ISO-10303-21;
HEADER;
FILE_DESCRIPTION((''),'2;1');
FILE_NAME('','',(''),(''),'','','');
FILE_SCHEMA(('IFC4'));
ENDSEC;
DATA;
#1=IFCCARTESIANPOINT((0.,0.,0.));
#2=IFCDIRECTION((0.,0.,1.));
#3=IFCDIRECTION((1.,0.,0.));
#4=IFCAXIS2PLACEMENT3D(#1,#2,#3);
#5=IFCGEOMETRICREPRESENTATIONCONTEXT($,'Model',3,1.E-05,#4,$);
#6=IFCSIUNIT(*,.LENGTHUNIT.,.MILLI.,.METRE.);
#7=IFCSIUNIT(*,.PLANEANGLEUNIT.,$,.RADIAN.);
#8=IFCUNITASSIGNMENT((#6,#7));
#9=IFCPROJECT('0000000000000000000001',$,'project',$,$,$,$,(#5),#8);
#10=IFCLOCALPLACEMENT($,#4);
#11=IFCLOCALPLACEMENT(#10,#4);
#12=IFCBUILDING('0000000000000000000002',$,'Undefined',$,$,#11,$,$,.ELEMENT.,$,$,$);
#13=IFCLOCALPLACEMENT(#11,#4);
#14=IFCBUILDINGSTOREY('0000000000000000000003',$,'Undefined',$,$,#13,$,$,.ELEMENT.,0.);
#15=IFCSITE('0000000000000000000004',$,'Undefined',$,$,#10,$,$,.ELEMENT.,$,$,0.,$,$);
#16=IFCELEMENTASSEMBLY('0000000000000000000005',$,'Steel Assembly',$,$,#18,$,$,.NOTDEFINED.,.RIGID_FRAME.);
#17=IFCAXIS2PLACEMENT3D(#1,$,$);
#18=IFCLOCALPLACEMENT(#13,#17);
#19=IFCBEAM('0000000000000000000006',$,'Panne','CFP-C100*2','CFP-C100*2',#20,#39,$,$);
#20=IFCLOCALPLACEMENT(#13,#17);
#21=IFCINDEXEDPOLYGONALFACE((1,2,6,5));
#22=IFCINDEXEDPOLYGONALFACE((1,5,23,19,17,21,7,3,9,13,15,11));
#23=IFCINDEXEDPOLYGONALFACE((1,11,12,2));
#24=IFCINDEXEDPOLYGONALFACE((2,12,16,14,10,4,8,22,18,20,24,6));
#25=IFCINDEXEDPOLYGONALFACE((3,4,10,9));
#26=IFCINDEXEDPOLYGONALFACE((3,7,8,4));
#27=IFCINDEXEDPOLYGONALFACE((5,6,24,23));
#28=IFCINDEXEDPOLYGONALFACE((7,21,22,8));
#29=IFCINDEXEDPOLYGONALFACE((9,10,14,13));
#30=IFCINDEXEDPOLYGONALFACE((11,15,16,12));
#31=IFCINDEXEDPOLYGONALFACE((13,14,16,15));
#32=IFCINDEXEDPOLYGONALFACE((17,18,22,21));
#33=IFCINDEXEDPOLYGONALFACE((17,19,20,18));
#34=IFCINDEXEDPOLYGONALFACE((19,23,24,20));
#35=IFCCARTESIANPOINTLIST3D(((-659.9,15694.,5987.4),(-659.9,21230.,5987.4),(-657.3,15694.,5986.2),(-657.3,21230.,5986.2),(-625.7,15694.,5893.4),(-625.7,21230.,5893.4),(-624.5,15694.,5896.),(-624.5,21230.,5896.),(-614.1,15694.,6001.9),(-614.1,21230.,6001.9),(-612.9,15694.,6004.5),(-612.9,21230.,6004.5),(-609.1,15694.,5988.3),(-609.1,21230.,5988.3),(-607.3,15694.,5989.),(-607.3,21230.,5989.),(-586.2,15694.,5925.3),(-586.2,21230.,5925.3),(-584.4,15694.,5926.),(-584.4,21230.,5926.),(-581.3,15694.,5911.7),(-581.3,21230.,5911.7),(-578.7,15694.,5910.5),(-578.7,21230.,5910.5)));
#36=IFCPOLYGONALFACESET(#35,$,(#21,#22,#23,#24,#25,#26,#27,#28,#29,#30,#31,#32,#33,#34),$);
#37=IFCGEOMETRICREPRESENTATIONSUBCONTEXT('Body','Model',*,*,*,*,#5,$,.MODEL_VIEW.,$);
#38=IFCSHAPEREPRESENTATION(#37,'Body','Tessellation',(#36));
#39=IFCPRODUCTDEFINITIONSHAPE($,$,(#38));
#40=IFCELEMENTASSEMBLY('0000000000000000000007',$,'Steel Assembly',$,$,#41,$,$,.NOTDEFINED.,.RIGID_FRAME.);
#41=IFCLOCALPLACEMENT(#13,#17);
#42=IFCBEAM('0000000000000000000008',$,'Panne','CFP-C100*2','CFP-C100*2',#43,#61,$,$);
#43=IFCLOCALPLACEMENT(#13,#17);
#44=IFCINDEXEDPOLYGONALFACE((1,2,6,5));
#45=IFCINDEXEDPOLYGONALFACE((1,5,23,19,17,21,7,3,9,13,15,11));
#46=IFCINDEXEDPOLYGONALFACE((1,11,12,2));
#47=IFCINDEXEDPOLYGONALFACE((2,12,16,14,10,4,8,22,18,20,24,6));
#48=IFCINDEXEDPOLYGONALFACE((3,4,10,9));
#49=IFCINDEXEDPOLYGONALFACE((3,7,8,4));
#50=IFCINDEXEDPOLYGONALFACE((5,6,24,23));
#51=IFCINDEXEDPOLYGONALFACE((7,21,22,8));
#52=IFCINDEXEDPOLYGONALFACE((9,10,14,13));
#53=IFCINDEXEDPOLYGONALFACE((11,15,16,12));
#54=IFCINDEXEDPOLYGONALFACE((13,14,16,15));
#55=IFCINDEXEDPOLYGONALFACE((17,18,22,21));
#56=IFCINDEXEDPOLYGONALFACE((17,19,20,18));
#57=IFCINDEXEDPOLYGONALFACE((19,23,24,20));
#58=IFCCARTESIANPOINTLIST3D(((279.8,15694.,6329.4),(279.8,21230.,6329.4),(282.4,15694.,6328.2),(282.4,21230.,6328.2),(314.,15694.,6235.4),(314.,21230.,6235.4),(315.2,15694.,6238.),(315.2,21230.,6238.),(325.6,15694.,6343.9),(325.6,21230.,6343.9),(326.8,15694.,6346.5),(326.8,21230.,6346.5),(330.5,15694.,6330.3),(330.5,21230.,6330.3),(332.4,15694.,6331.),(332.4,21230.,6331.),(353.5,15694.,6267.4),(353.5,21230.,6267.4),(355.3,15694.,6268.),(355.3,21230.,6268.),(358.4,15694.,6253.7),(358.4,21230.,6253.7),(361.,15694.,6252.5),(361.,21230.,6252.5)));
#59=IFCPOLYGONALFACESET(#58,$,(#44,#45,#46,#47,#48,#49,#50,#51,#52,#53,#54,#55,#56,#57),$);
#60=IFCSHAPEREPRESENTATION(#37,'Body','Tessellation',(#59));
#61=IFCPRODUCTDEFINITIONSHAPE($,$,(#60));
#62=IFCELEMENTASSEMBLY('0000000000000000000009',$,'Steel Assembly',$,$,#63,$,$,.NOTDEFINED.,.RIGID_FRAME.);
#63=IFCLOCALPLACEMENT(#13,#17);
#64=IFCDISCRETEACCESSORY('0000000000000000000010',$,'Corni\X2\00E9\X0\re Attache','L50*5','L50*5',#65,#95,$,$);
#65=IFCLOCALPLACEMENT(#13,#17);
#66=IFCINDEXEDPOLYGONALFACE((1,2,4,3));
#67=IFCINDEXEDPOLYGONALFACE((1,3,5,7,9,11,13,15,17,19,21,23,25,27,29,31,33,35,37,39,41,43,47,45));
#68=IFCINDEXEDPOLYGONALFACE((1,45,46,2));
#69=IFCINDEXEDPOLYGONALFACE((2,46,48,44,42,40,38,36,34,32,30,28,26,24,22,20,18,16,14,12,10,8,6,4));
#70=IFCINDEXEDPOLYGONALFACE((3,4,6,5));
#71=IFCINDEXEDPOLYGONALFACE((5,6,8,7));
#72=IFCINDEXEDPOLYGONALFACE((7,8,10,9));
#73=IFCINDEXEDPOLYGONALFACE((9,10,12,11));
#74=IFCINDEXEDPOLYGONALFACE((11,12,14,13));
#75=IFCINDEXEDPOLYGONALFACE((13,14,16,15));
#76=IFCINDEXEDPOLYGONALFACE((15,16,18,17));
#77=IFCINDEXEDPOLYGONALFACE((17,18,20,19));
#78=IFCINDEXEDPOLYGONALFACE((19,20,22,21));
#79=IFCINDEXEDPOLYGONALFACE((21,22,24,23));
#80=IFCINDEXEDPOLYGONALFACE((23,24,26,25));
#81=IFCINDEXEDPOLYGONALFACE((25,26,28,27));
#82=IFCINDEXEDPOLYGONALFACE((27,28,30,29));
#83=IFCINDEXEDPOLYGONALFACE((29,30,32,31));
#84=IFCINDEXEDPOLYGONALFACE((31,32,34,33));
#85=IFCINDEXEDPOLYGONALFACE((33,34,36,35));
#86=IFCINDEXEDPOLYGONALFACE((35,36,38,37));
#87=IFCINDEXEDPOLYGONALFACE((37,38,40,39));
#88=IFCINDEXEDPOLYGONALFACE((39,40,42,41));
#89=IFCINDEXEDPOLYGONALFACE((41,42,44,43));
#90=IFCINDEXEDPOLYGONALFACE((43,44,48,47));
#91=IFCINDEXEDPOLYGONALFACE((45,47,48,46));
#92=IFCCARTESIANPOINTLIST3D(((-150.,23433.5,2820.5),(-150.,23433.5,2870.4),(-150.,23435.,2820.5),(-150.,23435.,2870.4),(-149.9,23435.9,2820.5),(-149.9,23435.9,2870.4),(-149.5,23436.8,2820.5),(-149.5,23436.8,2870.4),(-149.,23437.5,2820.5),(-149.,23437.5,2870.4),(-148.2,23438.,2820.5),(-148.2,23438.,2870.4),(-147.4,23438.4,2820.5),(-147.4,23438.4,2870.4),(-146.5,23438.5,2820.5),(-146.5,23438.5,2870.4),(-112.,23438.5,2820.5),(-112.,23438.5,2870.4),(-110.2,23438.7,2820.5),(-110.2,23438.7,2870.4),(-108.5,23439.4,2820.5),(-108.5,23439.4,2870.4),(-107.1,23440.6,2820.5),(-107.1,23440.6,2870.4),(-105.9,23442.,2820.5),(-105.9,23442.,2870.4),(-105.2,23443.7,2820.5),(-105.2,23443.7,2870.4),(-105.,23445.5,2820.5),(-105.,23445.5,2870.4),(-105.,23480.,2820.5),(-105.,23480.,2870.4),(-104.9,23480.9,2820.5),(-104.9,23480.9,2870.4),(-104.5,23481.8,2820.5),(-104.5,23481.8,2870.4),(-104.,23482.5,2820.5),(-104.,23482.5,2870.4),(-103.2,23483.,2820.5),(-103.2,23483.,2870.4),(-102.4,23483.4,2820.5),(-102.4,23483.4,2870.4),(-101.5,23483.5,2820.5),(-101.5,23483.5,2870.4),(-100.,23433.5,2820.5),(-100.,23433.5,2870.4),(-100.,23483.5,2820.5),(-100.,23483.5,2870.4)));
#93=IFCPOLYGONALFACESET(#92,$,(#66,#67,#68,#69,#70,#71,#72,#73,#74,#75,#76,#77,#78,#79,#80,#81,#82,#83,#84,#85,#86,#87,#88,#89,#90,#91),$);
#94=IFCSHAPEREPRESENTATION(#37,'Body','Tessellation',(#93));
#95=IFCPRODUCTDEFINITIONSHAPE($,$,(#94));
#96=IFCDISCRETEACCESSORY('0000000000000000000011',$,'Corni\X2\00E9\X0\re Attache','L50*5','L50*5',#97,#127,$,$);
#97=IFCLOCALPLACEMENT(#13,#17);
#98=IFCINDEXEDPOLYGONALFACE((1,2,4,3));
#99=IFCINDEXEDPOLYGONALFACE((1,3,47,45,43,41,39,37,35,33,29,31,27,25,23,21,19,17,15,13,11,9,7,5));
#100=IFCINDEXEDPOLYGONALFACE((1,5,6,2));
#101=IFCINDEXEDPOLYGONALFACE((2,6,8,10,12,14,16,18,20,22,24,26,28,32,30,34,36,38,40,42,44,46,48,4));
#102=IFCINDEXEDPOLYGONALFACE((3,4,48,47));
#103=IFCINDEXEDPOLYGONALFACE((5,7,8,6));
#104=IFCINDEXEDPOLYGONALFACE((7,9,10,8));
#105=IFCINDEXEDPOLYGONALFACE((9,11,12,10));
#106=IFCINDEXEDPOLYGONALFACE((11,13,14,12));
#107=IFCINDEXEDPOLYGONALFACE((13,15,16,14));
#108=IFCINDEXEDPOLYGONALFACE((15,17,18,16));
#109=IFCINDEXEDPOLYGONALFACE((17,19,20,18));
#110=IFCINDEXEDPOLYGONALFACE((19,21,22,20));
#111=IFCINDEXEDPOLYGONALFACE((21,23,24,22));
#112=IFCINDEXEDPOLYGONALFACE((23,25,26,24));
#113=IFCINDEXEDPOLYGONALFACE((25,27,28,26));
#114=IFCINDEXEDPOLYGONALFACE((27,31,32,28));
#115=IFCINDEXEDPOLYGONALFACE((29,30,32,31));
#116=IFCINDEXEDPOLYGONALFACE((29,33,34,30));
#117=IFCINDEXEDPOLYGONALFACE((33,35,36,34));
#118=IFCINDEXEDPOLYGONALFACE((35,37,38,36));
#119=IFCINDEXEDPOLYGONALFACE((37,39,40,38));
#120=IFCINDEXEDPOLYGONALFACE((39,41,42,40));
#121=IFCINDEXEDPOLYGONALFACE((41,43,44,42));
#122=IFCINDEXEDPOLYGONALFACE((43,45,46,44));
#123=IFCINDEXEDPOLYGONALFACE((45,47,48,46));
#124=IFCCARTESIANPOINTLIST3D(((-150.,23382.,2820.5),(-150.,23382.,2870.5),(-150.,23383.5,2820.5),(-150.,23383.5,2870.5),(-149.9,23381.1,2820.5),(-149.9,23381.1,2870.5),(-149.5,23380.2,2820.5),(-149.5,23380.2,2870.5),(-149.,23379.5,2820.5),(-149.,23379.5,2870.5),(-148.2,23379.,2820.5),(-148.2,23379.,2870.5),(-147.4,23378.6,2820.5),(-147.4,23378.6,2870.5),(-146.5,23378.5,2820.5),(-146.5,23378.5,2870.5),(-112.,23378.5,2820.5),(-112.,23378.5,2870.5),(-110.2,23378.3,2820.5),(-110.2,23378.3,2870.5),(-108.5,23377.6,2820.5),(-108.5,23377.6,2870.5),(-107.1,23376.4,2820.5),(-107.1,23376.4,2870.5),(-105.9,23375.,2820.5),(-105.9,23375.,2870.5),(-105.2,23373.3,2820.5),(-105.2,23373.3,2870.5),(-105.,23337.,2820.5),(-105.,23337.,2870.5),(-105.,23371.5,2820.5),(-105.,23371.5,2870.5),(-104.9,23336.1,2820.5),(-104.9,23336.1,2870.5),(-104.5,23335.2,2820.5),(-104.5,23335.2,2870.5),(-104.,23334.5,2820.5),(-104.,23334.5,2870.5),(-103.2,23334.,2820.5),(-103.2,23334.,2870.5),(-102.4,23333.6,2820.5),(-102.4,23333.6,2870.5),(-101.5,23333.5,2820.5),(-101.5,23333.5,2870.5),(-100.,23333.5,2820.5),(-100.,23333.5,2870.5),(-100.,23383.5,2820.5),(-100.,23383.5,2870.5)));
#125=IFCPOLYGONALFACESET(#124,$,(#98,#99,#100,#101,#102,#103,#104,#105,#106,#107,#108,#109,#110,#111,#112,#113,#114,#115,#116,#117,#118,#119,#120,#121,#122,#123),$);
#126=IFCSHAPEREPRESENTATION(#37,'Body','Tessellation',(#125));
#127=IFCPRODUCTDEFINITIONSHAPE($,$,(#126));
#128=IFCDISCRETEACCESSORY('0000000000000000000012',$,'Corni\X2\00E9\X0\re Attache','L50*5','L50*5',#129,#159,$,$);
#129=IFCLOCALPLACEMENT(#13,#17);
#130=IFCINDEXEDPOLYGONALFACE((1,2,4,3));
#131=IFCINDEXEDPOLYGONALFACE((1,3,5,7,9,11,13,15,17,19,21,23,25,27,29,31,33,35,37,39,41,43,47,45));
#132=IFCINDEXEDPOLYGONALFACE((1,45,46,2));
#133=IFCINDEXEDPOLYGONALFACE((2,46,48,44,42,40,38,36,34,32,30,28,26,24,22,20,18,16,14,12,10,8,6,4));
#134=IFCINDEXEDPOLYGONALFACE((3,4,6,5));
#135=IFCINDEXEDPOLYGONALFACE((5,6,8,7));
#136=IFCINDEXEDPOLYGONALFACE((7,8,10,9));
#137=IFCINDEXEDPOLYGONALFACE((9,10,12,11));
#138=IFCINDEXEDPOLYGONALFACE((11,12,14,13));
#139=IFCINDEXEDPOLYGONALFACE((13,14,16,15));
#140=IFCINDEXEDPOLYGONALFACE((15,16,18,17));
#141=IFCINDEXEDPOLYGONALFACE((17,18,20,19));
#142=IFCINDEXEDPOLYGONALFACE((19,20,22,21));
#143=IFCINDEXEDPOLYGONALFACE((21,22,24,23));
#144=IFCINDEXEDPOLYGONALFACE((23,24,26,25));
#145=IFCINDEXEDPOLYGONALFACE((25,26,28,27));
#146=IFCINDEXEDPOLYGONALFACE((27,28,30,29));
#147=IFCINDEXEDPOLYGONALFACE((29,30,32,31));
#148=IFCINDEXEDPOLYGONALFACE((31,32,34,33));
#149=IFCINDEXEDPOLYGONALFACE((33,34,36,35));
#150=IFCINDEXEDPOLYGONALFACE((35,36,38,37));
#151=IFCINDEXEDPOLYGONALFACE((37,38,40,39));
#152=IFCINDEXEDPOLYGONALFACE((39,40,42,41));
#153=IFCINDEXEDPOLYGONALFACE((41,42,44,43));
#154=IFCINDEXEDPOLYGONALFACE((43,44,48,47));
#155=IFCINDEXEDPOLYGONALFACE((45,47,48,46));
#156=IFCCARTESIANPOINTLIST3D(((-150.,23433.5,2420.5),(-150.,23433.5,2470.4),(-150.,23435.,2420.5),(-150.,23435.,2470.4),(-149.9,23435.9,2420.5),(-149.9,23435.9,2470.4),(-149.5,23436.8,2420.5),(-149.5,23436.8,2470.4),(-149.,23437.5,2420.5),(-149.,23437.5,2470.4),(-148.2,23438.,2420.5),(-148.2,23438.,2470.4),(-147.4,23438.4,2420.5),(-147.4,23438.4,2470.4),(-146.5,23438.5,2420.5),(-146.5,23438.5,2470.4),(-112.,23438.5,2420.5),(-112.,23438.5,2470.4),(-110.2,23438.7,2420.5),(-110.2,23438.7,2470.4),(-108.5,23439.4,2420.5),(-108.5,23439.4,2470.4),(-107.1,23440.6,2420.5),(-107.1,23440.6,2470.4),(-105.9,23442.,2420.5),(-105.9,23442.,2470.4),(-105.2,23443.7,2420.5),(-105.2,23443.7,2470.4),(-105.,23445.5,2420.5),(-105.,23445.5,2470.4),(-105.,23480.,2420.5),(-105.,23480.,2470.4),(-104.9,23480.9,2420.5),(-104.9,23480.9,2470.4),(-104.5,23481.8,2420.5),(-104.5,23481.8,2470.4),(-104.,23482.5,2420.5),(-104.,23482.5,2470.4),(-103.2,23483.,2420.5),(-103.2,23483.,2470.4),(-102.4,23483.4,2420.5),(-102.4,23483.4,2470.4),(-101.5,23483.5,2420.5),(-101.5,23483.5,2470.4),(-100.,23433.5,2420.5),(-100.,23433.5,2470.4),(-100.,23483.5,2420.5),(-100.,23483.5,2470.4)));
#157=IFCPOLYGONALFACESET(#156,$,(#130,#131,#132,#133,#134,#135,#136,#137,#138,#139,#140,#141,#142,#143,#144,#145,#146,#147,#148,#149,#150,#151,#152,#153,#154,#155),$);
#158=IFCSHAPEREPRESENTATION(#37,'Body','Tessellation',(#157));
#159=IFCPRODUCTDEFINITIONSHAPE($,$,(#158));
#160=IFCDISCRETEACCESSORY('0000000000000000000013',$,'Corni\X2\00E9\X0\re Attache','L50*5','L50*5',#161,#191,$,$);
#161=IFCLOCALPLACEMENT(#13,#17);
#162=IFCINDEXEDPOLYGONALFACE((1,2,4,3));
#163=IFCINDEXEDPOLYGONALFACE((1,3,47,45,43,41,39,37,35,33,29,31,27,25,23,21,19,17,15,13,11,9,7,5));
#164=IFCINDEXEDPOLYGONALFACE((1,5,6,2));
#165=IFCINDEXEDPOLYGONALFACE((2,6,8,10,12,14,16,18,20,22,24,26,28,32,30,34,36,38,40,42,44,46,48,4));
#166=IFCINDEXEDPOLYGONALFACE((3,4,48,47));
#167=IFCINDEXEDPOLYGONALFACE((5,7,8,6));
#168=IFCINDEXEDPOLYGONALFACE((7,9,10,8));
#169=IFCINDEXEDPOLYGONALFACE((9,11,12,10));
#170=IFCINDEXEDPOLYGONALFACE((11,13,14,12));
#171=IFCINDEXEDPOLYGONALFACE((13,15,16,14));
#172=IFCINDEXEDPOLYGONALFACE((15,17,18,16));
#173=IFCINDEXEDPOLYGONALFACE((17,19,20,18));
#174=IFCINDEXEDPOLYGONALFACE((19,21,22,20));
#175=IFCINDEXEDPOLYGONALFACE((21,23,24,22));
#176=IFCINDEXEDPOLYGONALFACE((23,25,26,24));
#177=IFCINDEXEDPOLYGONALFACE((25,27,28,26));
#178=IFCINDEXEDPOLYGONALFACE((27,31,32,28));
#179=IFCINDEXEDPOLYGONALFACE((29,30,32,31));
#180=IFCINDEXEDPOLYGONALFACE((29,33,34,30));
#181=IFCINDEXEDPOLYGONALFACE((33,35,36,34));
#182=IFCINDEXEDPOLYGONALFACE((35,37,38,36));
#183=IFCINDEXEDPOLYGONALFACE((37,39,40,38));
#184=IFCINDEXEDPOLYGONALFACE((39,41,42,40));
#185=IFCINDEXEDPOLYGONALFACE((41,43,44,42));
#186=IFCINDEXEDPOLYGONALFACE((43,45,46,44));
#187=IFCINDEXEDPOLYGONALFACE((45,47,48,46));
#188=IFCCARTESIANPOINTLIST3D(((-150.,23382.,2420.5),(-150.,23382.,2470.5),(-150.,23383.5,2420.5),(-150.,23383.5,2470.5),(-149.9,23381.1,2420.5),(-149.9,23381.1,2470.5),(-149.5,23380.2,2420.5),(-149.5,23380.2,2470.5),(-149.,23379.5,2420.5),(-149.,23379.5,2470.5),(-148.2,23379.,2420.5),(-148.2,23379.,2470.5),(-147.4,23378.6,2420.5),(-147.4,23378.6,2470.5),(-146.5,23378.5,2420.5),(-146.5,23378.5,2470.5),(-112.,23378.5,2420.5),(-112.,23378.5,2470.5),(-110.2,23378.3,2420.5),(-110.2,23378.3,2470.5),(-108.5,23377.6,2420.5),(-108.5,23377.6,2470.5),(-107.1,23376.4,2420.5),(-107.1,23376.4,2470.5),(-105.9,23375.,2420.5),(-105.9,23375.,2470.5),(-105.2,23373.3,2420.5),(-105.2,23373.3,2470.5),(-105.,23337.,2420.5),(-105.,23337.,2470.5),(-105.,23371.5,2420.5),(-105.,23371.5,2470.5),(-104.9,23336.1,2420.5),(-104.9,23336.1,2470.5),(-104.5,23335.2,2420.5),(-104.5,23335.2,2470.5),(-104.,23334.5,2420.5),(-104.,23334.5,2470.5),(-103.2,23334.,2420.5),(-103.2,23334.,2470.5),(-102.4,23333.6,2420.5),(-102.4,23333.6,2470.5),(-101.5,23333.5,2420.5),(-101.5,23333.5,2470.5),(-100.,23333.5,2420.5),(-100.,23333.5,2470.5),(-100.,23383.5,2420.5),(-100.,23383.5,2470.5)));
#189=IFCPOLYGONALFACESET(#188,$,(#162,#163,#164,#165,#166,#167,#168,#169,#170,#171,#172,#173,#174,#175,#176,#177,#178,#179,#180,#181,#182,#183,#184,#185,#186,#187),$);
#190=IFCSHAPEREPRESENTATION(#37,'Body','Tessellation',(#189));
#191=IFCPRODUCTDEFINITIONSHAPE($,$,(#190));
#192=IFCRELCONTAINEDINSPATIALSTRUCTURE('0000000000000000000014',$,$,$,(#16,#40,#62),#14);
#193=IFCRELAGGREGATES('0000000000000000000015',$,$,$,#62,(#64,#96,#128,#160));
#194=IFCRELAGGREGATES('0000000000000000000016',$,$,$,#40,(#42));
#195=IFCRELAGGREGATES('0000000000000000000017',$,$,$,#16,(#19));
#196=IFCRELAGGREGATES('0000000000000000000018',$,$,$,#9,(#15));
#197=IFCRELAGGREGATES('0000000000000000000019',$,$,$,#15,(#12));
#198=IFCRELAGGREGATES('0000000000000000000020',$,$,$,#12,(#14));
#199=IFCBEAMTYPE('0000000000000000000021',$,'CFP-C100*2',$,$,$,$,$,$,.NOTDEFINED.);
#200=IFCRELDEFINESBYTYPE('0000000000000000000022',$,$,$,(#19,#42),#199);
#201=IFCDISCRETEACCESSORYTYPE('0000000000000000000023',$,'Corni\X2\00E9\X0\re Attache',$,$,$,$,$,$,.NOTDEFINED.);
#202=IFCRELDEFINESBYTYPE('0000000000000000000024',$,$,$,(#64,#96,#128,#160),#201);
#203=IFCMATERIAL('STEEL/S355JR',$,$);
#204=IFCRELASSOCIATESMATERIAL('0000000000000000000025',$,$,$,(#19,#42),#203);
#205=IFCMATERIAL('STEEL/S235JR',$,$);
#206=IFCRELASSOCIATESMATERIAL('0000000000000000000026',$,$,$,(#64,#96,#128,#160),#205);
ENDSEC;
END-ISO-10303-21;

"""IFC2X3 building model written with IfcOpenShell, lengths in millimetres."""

from ifc_helpers import new_model, si_unit, frame, origin_with_axes, origin_2d_with_axis, place, context, subcontext, project, spatial, l_section, c_section, extrude, material, type_object, element, aggregate, save


model = new_model("IFC2X3")

# Units and contexts
model_context = context("Model", 3, precision=1e-05, world=origin_with_axes())
body_context = subcontext(model_context, "Body", "Model", "MODEL_VIEW")
ifc_project = project(units=[si_unit("LENGTHUNIT", "METRE", prefix="MILLI"), si_unit("PLANEANGLEUNIT", "RADIAN")], contexts=[model_context])

# Site, building, storey
site_placement = place(None, origin_with_axes())
site = spatial("IfcSite", under=ifc_project, at=site_placement, Name="Undefined", CompositionType="ELEMENT", RefElevation=0.0)
building_placement = place(site_placement, origin_with_axes())
building = spatial("IfcBuilding", under=site, at=building_placement, Name="Undefined", CompositionType="ELEMENT")
storey_placement = place(building_placement, origin_with_axes())
storey = spatial("IfcBuildingStorey", under=building, at=storey_placement, Name="Undefined", CompositionType="ELEMENT", Elevation=0.0)

# Element assemblies, beams
ifc_material_1 = material(Name="STEEL/S355JR")
beam_type = type_object("IfcBeamType", Name="CFP-C100*2", PredefinedType="NOTDEFINED")
assembly_1_placement = place(storey_placement, origin_with_axes())
assembly_1 = element("IfcElementAssembly", 1, at=assembly_1_placement, inside=storey, Name="Steel Assembly", AssemblyPlace="NOTDEFINED", PredefinedType="RIGID_FRAME")
beam_1_placement = place(assembly_1_placement, frame((-619.3, 21230.0, 5949.0), z_axis=(0.34202, 0.0, -0.939693), x_axis=(0.0, -1.0, 0.0)))
beam_1 = element("IfcBeam", 2, at=beam_1_placement, type_object=beam_type, material=ifc_material_1, Name="Panne", Description="CFP-C100*2", ObjectType="CFP-C100*2", context=body_context, shape_type="SweptSolid", body=[
    extrude(c_section(Depth=100.0, Width=50.0, WallThickness=2.0, Girth=16.5, at=origin_2d_with_axis()), frame((5536.0, 0.0, 0.0), z_axis=(-1.0, 0.0, 0.0), x_axis=(0.0, -1.0, 0.0)), (0.0, 0.0, 1.0), 5536.0),
])
assembly_2_placement = place(storey_placement, origin_with_axes())
assembly_2 = element("IfcElementAssembly", 3, at=assembly_2_placement, inside=storey, Name="Steel Assembly", AssemblyPlace="NOTDEFINED", PredefinedType="RIGID_FRAME")
beam_2_placement = place(assembly_2_placement, frame((320.4, 21230.0, 6291.0), z_axis=(0.34202, 0.0, -0.939693), x_axis=(0.0, -1.0, 0.0)))
beam_2 = element("IfcBeam", 4, at=beam_2_placement, type_object=beam_type, material=ifc_material_1, Name="Panne", Description="CFP-C100*2", ObjectType="CFP-C100*2", context=body_context, shape_type="SweptSolid", body=[
    extrude(c_section(Depth=100.0, Width=50.0, WallThickness=2.0, Girth=16.5, at=origin_2d_with_axis()), frame((5536.0, 0.0, 0.0), z_axis=(-1.0, 0.0, 0.0), x_axis=(0.0, -1.0, 0.0)), (0.0, 0.0, 1.0), 5536.0),
])

# Element assembly
assembly_3_placement = place(storey_placement, origin_with_axes())
assembly_3 = element("IfcElementAssembly", 5, at=assembly_3_placement, inside=storey, Name="Steel Assembly", AssemblyPlace="NOTDEFINED", PredefinedType="RIGID_FRAME")
ifc_material_2 = material(Name="STEEL/S235JR")

# Discrete accessories
discrete_accessory_type_1 = type_object("IfcDiscreteAccessoryType", Name="Corniére Attache")
discrete_accessory_1_placement = place(assembly_3_placement, frame((-125.0, 23458.5, 2870.4), z_axis=(-1.0, 0.0, 0.0), x_axis=(0.0, 0.0, -1.0)))
discrete_accessory_1 = element("IfcDiscreteAccessory", 6, at=discrete_accessory_1_placement, type_object=discrete_accessory_type_1, material=ifc_material_2, Name="Corniére Attache", Description="L50*5", ObjectType="L50*5", context=body_context, shape_type="SweptSolid", body=[
    extrude(l_section(Depth=50.0, Width=50.0, Thickness=5.0, FilletRadius=7.0, EdgeRadius=3.5, at=origin_2d_with_axis()), frame((49.9, 0.0, 0.0), z_axis=(-1.0, 0.0, 0.0), x_axis=(0.0, -1.0, 0.0)), (0.0, 0.0, 1.0), 49.9),
])
discrete_accessory_2_placement = place(assembly_3_placement, frame((-125.0, 23358.5, 2820.5), z_axis=(0.0, 0.0, 1.0), x_axis=(1.0, 0.0, 0.0)))
discrete_accessory_2 = element("IfcDiscreteAccessory", 7, at=discrete_accessory_2_placement, type_object=discrete_accessory_type_1, material=ifc_material_2, Name="Corniére Attache", Description="L50*5", ObjectType="L50*5", context=body_context, shape_type="SweptSolid", body=[
    extrude(l_section(Depth=50.0, Width=50.0, Thickness=5.0, FilletRadius=7.0, EdgeRadius=3.5, at=origin_2d_with_axis()), frame((0.0, 0.0, 50.0), z_axis=(0.0, 0.0, -1.0), x_axis=(0.0, -1.0, 0.0)), (0.0, 0.0, 1.0), 50.0),
])
discrete_accessory_3_placement = place(assembly_3_placement, frame((-125.0, 23458.5, 2470.4), z_axis=(-1.0, 0.0, 0.0), x_axis=(0.0, 0.0, -1.0)))
discrete_accessory_3 = element("IfcDiscreteAccessory", 8, at=discrete_accessory_3_placement, type_object=discrete_accessory_type_1, material=ifc_material_2, Name="Corniére Attache", Description="L50*5", ObjectType="L50*5", context=body_context, shape_type="SweptSolid", body=[
    extrude(l_section(Depth=50.0, Width=50.0, Thickness=5.0, FilletRadius=7.0, EdgeRadius=3.5, at=origin_2d_with_axis()), frame((49.9, 0.0, 0.0), z_axis=(-1.0, 0.0, 0.0), x_axis=(0.0, -1.0, 0.0)), (0.0, 0.0, 1.0), 49.9),
])
discrete_accessory_4_placement = place(assembly_3_placement, frame((-125.0, 23358.5, 2420.5), z_axis=(0.0, 0.0, 1.0), x_axis=(1.0, 0.0, 0.0)))
discrete_accessory_4 = element("IfcDiscreteAccessory", 9, at=discrete_accessory_4_placement, type_object=discrete_accessory_type_1, material=ifc_material_2, Name="Corniére Attache", Description="L50*5", ObjectType="L50*5", context=body_context, shape_type="SweptSolid", body=[
    extrude(l_section(Depth=50.0, Width=50.0, Thickness=5.0, FilletRadius=7.0, EdgeRadius=3.5, at=origin_2d_with_axis()), frame((0.0, 0.0, 50.0), z_axis=(0.0, 0.0, -1.0), x_axis=(0.0, -1.0, 0.0)), (0.0, 0.0, 1.0), 50.0),
])

aggregate(assembly_3, [discrete_accessory_1, discrete_accessory_2, discrete_accessory_3, discrete_accessory_4])

aggregate(assembly_2, [beam_2])

aggregate(assembly_1, [beam_1])

save(model, "model.ifc")
